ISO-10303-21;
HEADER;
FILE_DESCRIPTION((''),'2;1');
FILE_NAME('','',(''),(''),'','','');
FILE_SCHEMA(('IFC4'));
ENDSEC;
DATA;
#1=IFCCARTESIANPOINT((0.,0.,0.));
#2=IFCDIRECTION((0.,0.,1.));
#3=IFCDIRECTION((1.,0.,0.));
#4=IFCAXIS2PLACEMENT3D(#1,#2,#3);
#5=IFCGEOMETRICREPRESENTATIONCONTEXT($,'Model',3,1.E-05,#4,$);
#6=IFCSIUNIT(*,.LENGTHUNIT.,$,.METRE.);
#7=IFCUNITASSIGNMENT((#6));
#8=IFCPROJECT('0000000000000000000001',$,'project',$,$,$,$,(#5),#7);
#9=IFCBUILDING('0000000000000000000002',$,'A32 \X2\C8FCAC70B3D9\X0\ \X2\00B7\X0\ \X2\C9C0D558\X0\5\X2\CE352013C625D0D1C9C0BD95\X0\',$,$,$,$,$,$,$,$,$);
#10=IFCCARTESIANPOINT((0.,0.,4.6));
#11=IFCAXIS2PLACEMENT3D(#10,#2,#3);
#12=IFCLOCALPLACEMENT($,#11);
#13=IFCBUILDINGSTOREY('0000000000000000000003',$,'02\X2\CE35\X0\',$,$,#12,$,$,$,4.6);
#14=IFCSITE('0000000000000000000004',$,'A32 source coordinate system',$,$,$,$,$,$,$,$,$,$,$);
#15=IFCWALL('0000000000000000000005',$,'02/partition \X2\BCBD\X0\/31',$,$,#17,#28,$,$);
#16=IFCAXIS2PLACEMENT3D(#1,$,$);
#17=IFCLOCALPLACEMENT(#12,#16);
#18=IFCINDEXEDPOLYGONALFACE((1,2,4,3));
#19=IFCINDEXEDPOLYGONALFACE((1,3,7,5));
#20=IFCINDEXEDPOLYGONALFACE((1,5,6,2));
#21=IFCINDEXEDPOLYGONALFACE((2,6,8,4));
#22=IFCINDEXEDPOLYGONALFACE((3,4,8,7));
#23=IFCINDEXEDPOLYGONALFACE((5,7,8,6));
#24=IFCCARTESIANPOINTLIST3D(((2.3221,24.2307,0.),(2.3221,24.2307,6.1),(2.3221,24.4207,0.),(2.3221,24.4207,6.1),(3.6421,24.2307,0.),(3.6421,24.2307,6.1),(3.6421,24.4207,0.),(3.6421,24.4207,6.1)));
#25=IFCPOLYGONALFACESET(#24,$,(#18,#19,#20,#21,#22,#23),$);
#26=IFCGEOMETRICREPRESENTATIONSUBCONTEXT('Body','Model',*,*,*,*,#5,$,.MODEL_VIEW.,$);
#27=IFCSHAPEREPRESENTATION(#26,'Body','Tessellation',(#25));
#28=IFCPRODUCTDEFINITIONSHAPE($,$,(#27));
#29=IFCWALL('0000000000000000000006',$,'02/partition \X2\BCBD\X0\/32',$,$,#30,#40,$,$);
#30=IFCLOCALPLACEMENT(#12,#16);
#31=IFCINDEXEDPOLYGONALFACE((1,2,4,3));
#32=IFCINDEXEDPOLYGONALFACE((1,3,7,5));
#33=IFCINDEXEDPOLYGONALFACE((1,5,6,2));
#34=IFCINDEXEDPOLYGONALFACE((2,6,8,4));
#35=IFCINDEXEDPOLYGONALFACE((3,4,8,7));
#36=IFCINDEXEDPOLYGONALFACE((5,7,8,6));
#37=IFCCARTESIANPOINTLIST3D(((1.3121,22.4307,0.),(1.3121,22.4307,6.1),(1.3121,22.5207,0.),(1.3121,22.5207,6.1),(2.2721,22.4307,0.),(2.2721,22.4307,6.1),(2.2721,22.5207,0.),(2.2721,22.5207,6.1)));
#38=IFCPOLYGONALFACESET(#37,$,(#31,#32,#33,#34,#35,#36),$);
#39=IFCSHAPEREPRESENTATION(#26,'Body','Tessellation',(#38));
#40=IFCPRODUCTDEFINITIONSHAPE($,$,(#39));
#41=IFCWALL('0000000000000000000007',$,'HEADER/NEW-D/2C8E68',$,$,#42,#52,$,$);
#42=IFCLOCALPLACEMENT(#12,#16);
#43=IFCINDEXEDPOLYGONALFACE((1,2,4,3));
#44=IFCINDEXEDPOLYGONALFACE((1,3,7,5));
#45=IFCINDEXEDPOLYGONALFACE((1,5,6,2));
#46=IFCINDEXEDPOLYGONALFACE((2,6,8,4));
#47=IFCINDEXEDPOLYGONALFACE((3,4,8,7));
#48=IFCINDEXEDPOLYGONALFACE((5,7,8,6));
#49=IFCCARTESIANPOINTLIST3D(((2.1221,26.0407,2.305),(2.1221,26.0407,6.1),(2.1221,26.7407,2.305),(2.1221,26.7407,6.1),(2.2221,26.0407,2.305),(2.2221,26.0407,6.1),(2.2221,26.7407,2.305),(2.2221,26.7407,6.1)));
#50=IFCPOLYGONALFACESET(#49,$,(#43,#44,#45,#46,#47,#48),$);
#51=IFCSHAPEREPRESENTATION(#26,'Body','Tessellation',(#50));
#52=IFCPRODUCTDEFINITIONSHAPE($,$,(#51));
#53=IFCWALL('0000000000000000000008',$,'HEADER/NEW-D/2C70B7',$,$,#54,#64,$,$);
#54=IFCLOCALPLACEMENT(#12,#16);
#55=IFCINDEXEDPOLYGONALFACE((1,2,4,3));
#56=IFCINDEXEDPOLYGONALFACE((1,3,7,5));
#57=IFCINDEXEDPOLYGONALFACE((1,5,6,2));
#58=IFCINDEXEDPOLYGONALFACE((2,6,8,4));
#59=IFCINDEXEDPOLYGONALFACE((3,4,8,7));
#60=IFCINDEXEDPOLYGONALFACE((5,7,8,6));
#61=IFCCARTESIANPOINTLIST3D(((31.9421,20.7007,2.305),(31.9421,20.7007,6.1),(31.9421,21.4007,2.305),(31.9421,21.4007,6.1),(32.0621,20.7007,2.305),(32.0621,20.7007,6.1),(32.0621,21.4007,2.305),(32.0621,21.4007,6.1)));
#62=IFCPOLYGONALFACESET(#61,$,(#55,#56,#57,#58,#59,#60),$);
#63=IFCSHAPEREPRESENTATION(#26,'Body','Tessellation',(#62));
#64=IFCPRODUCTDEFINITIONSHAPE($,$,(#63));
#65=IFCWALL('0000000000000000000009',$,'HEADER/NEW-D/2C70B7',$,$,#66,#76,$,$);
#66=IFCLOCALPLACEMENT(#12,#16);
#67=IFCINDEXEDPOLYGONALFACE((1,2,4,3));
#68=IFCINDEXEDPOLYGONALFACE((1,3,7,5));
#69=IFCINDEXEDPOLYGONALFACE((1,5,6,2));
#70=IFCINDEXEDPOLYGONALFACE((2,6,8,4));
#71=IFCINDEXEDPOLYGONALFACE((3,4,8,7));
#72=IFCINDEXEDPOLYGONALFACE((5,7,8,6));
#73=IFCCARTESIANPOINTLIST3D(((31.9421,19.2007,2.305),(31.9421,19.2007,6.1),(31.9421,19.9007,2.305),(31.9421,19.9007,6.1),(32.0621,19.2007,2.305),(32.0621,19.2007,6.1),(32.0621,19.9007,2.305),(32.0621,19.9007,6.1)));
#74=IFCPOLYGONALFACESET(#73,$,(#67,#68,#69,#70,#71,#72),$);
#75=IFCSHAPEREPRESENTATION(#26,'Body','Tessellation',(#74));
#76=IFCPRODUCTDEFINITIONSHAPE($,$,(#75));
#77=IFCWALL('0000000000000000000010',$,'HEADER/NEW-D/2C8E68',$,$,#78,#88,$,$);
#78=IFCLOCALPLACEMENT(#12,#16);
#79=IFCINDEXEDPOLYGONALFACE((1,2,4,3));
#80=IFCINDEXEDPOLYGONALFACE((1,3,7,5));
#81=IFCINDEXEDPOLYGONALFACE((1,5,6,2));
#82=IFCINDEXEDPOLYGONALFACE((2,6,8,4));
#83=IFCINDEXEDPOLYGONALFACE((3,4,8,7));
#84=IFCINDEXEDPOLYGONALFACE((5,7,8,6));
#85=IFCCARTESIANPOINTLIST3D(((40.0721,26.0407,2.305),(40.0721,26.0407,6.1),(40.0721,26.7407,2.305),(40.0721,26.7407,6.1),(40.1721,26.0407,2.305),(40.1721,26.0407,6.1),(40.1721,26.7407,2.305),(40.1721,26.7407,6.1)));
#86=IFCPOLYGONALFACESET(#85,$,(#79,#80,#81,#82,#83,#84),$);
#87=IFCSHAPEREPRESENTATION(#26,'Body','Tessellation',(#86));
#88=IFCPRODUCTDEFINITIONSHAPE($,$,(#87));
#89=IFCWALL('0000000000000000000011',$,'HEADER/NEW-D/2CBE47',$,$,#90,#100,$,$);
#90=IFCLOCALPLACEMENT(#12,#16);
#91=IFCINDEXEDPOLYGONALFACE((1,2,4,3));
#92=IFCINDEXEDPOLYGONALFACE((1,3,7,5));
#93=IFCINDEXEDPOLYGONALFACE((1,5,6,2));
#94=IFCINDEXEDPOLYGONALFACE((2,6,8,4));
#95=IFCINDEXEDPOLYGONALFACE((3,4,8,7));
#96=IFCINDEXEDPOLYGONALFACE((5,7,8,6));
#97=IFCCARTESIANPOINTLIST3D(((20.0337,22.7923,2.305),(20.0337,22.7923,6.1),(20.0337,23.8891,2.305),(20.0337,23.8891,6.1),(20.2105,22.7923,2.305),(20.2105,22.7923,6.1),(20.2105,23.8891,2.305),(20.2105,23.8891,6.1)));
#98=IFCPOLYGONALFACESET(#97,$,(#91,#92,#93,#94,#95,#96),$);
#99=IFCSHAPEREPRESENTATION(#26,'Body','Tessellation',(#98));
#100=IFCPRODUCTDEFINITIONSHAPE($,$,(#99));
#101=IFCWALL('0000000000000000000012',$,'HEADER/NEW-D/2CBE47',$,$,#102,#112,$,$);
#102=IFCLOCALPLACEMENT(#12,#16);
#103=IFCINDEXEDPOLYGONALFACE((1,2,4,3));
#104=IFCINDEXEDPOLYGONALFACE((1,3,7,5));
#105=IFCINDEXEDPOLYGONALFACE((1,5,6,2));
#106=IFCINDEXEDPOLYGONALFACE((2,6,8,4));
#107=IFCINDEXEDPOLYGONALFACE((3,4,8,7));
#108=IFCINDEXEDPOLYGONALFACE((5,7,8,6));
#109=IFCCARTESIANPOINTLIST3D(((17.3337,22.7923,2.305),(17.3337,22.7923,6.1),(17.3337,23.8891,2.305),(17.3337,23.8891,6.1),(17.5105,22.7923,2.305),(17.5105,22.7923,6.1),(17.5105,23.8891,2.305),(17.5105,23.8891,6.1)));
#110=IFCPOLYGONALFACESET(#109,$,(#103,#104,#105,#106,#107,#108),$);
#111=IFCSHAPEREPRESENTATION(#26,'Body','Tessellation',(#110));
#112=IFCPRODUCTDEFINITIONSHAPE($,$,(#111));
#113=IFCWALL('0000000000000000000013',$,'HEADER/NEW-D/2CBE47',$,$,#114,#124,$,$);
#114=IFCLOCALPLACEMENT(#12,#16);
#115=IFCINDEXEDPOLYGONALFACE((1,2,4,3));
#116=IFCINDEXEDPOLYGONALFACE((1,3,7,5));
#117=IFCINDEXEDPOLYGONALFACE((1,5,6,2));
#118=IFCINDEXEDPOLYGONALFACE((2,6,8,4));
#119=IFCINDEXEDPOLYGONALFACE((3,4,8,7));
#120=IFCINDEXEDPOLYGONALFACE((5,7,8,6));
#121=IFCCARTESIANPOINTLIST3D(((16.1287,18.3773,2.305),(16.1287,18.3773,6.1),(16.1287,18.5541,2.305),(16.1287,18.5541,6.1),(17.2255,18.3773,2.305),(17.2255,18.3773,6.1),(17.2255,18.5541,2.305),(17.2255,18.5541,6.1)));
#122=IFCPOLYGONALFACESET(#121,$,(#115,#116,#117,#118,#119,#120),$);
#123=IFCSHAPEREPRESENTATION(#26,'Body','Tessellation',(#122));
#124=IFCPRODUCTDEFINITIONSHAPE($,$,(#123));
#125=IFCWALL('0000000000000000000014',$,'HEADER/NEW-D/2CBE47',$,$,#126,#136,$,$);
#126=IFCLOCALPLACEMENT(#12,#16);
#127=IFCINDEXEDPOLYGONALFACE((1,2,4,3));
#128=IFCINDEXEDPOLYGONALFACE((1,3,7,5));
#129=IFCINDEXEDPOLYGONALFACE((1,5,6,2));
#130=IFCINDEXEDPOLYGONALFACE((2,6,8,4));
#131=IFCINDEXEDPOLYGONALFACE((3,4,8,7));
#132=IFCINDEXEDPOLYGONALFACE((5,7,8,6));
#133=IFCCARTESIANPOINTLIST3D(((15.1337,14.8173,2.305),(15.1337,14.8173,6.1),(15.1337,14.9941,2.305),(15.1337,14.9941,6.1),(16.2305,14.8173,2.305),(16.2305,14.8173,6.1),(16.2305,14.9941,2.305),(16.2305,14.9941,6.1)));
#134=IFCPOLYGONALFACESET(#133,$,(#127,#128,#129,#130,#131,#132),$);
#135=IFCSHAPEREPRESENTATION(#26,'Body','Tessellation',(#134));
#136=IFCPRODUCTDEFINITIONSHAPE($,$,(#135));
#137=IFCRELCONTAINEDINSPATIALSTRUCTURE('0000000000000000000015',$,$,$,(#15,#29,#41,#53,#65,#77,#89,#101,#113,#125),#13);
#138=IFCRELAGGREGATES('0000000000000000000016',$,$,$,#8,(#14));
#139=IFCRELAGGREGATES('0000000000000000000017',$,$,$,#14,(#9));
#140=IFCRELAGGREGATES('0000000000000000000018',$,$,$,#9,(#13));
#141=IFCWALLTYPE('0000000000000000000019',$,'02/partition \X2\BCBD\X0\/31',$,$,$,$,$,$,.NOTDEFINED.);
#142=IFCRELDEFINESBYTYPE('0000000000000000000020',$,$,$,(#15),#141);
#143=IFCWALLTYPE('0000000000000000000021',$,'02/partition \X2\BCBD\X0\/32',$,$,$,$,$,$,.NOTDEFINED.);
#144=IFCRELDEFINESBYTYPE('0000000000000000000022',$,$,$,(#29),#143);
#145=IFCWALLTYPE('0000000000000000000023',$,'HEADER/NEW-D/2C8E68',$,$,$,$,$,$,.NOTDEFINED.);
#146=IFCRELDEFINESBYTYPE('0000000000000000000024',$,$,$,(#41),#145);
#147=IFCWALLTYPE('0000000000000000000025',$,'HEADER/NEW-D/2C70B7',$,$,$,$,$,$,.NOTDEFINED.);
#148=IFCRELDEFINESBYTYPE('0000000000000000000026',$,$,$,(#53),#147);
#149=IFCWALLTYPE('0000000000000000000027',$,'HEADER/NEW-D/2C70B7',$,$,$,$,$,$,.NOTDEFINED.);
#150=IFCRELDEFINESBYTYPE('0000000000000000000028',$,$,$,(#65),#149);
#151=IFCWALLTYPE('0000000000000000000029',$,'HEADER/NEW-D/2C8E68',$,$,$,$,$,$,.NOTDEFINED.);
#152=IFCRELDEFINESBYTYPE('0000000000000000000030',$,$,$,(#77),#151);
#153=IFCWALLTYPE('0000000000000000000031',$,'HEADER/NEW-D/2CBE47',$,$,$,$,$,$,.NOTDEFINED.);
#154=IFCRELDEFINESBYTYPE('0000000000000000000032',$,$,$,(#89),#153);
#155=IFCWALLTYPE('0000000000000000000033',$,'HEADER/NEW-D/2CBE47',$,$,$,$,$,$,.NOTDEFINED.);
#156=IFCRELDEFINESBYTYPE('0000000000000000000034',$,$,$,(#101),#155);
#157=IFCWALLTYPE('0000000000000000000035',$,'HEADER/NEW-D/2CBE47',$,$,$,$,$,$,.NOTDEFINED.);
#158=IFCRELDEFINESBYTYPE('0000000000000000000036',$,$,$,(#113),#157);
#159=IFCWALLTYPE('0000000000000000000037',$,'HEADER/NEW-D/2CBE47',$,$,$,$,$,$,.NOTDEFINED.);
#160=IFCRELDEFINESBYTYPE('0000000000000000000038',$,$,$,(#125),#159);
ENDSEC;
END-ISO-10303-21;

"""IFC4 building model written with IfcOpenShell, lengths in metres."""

from ifc_helpers import new_model, si_unit, frame, origin, origin_with_axes, place, context, subcontext, project, spatial, polyline, outline, extrude, source, transform, mapped, type_object, type_shapes, element, save


model = new_model("IFC4")

# Units and contexts
model_context = context("Model", 3, precision=1e-05, world=origin_with_axes())
body_context = subcontext(model_context, "Body", "Model", "MODEL_VIEW")
ifc_project = project(units=[si_unit("LENGTHUNIT", "METRE")], contexts=[model_context])

# Site, building, storey
site = spatial("IfcSite", under=ifc_project, Name="A32 source coordinate system")
building = spatial("IfcBuilding", under=site, Name="A32 주거동 · 지하5층–옥탑지붕")
storey_placement = place(None, frame((0.0, 0.0, 4.6), z_axis=(0.0, 0.0, 1.0), x_axis=(1.0, 0.0, 0.0)))
storey = spatial("IfcBuildingStorey", under=building, at=storey_placement, Name="02층", Elevation=4.6)

# Walls
wall_type_1 = type_object("IfcWallType", Name="02/partition 벽/31", PredefinedType="NOTDEFINED")
shared_shape_1 = source(origin(), body_context, "Body", "SweptSolid", [
    extrude(outline(polyline([(3.6421, 24.4207), (3.6421, 24.2307), (2.3221, 24.2307), (2.3221, 24.4207), (3.6421, 24.4207)])), origin(), (0.0, 0.0, 1.0), 6.1),
])
type_shapes(wall_type_1, [shared_shape_1])
wall_1_placement = place(storey_placement, origin_with_axes())
element("IfcWall", 1, at=wall_1_placement, inside=storey, type_object=wall_type_1, Name="02/partition 벽/31", context=body_context, shape_type="MappedRepresentation", body=[
    mapped(shared_shape_1, transform((0.0, 0.0, 0.0), scale=1.0)),
])
wall_type_2 = type_object("IfcWallType", Name="02/partition 벽/32", PredefinedType="NOTDEFINED")
shared_shape_2 = source(origin(), body_context, "Body", "SweptSolid", [
    extrude(outline(polyline([(1.3121, 22.5207), (2.2721, 22.5207), (2.2721, 22.4307), (1.3121, 22.4307), (1.3121, 22.5207)])), origin(), (0.0, 0.0, 1.0), 6.1),
])
type_shapes(wall_type_2, [shared_shape_2])
wall_2_placement = place(storey_placement, origin_with_axes())
element("IfcWall", 2, at=wall_2_placement, inside=storey, type_object=wall_type_2, Name="02/partition 벽/32", context=body_context, shape_type="MappedRepresentation", body=[
    mapped(shared_shape_2, transform((0.0, 0.0, 0.0), scale=1.0)),
])
wall_type_3 = type_object("IfcWallType", Name="HEADER/NEW-D/2C8E68", PredefinedType="NOTDEFINED")
shared_shape_3 = source(origin(), body_context, "Body", "SweptSolid", [
    extrude(outline(polyline([(2.1221, 26.0407), (2.1221, 26.7407), (2.2221, 26.7407), (2.2221, 26.0407), (2.1221, 26.0407)])), frame((0.0, 0.0, 2.305)), (0.0, 0.0, 1.0), 3.795),
])
type_shapes(wall_type_3, [shared_shape_3])
wall_3_placement = place(storey_placement, origin_with_axes())
element("IfcWall", 3, at=wall_3_placement, inside=storey, type_object=wall_type_3, Name="HEADER/NEW-D/2C8E68", context=body_context, shape_type="MappedRepresentation", body=[
    mapped(shared_shape_3, transform((0.0, 0.0, 0.0), scale=1.0)),
])
wall_type_4 = type_object("IfcWallType", Name="HEADER/NEW-D/2C70B7", PredefinedType="NOTDEFINED")
shared_shape_4 = source(origin(), body_context, "Body", "SweptSolid", [
    extrude(outline(polyline([(31.9421, 20.7007), (31.9421, 21.4007), (32.0621, 21.4007), (32.0621, 20.7007), (31.9421, 20.7007)])), frame((0.0, 0.0, 2.305)), (0.0, 0.0, 1.0), 3.795),
])
type_shapes(wall_type_4, [shared_shape_4])
wall_4_placement = place(storey_placement, origin_with_axes())
element("IfcWall", 4, at=wall_4_placement, inside=storey, type_object=wall_type_4, Name="HEADER/NEW-D/2C70B7", context=body_context, shape_type="MappedRepresentation", body=[
    mapped(shared_shape_4, transform((0.0, 0.0, 0.0), scale=1.0)),
])
wall_type_5 = type_object("IfcWallType", Name="HEADER/NEW-D/2C70B7", PredefinedType="NOTDEFINED")
shared_shape_5 = source(origin(), body_context, "Body", "SweptSolid", [
    extrude(outline(polyline([(31.9421, 19.2007), (31.9421, 19.9007), (32.0621, 19.9007), (32.0621, 19.2007), (31.9421, 19.2007)])), frame((0.0, 0.0, 2.305)), (0.0, 0.0, 1.0), 3.795),
])
type_shapes(wall_type_5, [shared_shape_5])
wall_5_placement = place(storey_placement, origin_with_axes())
element("IfcWall", 5, at=wall_5_placement, inside=storey, type_object=wall_type_5, Name="HEADER/NEW-D/2C70B7", context=body_context, shape_type="MappedRepresentation", body=[
    mapped(shared_shape_5, transform((0.0, 0.0, 0.0), scale=1.0)),
])
wall_type_6 = type_object("IfcWallType", Name="HEADER/NEW-D/2C8E68", PredefinedType="NOTDEFINED")
shared_shape_6 = source(origin(), body_context, "Body", "SweptSolid", [
    extrude(outline(polyline([(40.0721, 26.0407), (40.0721, 26.7407), (40.1721, 26.7407), (40.1721, 26.0407), (40.0721, 26.0407)])), frame((0.0, 0.0, 2.305)), (0.0, 0.0, 1.0), 3.795),
])
type_shapes(wall_type_6, [shared_shape_6])
wall_6_placement = place(storey_placement, origin_with_axes())
element("IfcWall", 6, at=wall_6_placement, inside=storey, type_object=wall_type_6, Name="HEADER/NEW-D/2C8E68", context=body_context, shape_type="MappedRepresentation", body=[
    mapped(shared_shape_6, transform((0.0, 0.0, 0.0), scale=1.0)),
])
wall_type_7 = type_object("IfcWallType", Name="HEADER/NEW-D/2CBE47", PredefinedType="NOTDEFINED")
shared_shape_7 = source(origin(), body_context, "Body", "SweptSolid", [
    extrude(outline(polyline([(20.0337, 22.7923), (20.0337, 23.8891), (20.2105, 23.8891), (20.2105, 22.7923), (20.0337, 22.7923)])), frame((0.0, 0.0, 2.305)), (0.0, 0.0, 1.0), 3.795),
])
type_shapes(wall_type_7, [shared_shape_7])
wall_7_placement = place(storey_placement, origin_with_axes())
element("IfcWall", 7, at=wall_7_placement, inside=storey, type_object=wall_type_7, Name="HEADER/NEW-D/2CBE47", context=body_context, shape_type="MappedRepresentation", body=[
    mapped(shared_shape_7, transform((0.0, 0.0, 0.0), scale=1.0)),
])
wall_type_8 = type_object("IfcWallType", Name="HEADER/NEW-D/2CBE47", PredefinedType="NOTDEFINED")
shared_shape_8 = source(origin(), body_context, "Body", "SweptSolid", [
    extrude(outline(polyline([(17.3337, 22.7923), (17.3337, 23.8891), (17.5105, 23.8891), (17.5105, 22.7923), (17.3337, 22.7923)])), frame((0.0, 0.0, 2.305)), (0.0, 0.0, 1.0), 3.795),
])
type_shapes(wall_type_8, [shared_shape_8])
wall_8_placement = place(storey_placement, origin_with_axes())
element("IfcWall", 8, at=wall_8_placement, inside=storey, type_object=wall_type_8, Name="HEADER/NEW-D/2CBE47", context=body_context, shape_type="MappedRepresentation", body=[
    mapped(shared_shape_8, transform((0.0, 0.0, 0.0), scale=1.0)),
])
wall_type_9 = type_object("IfcWallType", Name="HEADER/NEW-D/2CBE47", PredefinedType="NOTDEFINED")
shared_shape_9 = source(origin(), body_context, "Body", "SweptSolid", [
    extrude(outline(polyline([(16.1287, 18.3773), (16.1287, 18.5541), (17.2255, 18.5541), (17.2255, 18.3773), (16.1287, 18.3773)])), frame((0.0, 0.0, 2.305)), (0.0, 0.0, 1.0), 3.795),
])
type_shapes(wall_type_9, [shared_shape_9])
wall_9_placement = place(storey_placement, origin_with_axes())
element("IfcWall", 9, at=wall_9_placement, inside=storey, type_object=wall_type_9, Name="HEADER/NEW-D/2CBE47", context=body_context, shape_type="MappedRepresentation", body=[
    mapped(shared_shape_9, transform((0.0, 0.0, 0.0), scale=1.0)),
])
wall_type_10 = type_object("IfcWallType", Name="HEADER/NEW-D/2CBE47", PredefinedType="NOTDEFINED")
shared_shape_10 = source(origin(), body_context, "Body", "SweptSolid", [
    extrude(outline(polyline([(15.1337, 14.8173), (15.1337, 14.9941), (16.2305, 14.9941), (16.2305, 14.8173), (15.1337, 14.8173)])), frame((0.0, 0.0, 2.305)), (0.0, 0.0, 1.0), 3.795),
])
type_shapes(wall_type_10, [shared_shape_10])
wall_10_placement = place(storey_placement, origin_with_axes())
element("IfcWall", 10, at=wall_10_placement, inside=storey, type_object=wall_type_10, Name="HEADER/NEW-D/2CBE47", context=body_context, shape_type="MappedRepresentation", body=[
    mapped(shared_shape_10, transform((0.0, 0.0, 0.0), scale=1.0)),
])

save(model, "model.ifc")
